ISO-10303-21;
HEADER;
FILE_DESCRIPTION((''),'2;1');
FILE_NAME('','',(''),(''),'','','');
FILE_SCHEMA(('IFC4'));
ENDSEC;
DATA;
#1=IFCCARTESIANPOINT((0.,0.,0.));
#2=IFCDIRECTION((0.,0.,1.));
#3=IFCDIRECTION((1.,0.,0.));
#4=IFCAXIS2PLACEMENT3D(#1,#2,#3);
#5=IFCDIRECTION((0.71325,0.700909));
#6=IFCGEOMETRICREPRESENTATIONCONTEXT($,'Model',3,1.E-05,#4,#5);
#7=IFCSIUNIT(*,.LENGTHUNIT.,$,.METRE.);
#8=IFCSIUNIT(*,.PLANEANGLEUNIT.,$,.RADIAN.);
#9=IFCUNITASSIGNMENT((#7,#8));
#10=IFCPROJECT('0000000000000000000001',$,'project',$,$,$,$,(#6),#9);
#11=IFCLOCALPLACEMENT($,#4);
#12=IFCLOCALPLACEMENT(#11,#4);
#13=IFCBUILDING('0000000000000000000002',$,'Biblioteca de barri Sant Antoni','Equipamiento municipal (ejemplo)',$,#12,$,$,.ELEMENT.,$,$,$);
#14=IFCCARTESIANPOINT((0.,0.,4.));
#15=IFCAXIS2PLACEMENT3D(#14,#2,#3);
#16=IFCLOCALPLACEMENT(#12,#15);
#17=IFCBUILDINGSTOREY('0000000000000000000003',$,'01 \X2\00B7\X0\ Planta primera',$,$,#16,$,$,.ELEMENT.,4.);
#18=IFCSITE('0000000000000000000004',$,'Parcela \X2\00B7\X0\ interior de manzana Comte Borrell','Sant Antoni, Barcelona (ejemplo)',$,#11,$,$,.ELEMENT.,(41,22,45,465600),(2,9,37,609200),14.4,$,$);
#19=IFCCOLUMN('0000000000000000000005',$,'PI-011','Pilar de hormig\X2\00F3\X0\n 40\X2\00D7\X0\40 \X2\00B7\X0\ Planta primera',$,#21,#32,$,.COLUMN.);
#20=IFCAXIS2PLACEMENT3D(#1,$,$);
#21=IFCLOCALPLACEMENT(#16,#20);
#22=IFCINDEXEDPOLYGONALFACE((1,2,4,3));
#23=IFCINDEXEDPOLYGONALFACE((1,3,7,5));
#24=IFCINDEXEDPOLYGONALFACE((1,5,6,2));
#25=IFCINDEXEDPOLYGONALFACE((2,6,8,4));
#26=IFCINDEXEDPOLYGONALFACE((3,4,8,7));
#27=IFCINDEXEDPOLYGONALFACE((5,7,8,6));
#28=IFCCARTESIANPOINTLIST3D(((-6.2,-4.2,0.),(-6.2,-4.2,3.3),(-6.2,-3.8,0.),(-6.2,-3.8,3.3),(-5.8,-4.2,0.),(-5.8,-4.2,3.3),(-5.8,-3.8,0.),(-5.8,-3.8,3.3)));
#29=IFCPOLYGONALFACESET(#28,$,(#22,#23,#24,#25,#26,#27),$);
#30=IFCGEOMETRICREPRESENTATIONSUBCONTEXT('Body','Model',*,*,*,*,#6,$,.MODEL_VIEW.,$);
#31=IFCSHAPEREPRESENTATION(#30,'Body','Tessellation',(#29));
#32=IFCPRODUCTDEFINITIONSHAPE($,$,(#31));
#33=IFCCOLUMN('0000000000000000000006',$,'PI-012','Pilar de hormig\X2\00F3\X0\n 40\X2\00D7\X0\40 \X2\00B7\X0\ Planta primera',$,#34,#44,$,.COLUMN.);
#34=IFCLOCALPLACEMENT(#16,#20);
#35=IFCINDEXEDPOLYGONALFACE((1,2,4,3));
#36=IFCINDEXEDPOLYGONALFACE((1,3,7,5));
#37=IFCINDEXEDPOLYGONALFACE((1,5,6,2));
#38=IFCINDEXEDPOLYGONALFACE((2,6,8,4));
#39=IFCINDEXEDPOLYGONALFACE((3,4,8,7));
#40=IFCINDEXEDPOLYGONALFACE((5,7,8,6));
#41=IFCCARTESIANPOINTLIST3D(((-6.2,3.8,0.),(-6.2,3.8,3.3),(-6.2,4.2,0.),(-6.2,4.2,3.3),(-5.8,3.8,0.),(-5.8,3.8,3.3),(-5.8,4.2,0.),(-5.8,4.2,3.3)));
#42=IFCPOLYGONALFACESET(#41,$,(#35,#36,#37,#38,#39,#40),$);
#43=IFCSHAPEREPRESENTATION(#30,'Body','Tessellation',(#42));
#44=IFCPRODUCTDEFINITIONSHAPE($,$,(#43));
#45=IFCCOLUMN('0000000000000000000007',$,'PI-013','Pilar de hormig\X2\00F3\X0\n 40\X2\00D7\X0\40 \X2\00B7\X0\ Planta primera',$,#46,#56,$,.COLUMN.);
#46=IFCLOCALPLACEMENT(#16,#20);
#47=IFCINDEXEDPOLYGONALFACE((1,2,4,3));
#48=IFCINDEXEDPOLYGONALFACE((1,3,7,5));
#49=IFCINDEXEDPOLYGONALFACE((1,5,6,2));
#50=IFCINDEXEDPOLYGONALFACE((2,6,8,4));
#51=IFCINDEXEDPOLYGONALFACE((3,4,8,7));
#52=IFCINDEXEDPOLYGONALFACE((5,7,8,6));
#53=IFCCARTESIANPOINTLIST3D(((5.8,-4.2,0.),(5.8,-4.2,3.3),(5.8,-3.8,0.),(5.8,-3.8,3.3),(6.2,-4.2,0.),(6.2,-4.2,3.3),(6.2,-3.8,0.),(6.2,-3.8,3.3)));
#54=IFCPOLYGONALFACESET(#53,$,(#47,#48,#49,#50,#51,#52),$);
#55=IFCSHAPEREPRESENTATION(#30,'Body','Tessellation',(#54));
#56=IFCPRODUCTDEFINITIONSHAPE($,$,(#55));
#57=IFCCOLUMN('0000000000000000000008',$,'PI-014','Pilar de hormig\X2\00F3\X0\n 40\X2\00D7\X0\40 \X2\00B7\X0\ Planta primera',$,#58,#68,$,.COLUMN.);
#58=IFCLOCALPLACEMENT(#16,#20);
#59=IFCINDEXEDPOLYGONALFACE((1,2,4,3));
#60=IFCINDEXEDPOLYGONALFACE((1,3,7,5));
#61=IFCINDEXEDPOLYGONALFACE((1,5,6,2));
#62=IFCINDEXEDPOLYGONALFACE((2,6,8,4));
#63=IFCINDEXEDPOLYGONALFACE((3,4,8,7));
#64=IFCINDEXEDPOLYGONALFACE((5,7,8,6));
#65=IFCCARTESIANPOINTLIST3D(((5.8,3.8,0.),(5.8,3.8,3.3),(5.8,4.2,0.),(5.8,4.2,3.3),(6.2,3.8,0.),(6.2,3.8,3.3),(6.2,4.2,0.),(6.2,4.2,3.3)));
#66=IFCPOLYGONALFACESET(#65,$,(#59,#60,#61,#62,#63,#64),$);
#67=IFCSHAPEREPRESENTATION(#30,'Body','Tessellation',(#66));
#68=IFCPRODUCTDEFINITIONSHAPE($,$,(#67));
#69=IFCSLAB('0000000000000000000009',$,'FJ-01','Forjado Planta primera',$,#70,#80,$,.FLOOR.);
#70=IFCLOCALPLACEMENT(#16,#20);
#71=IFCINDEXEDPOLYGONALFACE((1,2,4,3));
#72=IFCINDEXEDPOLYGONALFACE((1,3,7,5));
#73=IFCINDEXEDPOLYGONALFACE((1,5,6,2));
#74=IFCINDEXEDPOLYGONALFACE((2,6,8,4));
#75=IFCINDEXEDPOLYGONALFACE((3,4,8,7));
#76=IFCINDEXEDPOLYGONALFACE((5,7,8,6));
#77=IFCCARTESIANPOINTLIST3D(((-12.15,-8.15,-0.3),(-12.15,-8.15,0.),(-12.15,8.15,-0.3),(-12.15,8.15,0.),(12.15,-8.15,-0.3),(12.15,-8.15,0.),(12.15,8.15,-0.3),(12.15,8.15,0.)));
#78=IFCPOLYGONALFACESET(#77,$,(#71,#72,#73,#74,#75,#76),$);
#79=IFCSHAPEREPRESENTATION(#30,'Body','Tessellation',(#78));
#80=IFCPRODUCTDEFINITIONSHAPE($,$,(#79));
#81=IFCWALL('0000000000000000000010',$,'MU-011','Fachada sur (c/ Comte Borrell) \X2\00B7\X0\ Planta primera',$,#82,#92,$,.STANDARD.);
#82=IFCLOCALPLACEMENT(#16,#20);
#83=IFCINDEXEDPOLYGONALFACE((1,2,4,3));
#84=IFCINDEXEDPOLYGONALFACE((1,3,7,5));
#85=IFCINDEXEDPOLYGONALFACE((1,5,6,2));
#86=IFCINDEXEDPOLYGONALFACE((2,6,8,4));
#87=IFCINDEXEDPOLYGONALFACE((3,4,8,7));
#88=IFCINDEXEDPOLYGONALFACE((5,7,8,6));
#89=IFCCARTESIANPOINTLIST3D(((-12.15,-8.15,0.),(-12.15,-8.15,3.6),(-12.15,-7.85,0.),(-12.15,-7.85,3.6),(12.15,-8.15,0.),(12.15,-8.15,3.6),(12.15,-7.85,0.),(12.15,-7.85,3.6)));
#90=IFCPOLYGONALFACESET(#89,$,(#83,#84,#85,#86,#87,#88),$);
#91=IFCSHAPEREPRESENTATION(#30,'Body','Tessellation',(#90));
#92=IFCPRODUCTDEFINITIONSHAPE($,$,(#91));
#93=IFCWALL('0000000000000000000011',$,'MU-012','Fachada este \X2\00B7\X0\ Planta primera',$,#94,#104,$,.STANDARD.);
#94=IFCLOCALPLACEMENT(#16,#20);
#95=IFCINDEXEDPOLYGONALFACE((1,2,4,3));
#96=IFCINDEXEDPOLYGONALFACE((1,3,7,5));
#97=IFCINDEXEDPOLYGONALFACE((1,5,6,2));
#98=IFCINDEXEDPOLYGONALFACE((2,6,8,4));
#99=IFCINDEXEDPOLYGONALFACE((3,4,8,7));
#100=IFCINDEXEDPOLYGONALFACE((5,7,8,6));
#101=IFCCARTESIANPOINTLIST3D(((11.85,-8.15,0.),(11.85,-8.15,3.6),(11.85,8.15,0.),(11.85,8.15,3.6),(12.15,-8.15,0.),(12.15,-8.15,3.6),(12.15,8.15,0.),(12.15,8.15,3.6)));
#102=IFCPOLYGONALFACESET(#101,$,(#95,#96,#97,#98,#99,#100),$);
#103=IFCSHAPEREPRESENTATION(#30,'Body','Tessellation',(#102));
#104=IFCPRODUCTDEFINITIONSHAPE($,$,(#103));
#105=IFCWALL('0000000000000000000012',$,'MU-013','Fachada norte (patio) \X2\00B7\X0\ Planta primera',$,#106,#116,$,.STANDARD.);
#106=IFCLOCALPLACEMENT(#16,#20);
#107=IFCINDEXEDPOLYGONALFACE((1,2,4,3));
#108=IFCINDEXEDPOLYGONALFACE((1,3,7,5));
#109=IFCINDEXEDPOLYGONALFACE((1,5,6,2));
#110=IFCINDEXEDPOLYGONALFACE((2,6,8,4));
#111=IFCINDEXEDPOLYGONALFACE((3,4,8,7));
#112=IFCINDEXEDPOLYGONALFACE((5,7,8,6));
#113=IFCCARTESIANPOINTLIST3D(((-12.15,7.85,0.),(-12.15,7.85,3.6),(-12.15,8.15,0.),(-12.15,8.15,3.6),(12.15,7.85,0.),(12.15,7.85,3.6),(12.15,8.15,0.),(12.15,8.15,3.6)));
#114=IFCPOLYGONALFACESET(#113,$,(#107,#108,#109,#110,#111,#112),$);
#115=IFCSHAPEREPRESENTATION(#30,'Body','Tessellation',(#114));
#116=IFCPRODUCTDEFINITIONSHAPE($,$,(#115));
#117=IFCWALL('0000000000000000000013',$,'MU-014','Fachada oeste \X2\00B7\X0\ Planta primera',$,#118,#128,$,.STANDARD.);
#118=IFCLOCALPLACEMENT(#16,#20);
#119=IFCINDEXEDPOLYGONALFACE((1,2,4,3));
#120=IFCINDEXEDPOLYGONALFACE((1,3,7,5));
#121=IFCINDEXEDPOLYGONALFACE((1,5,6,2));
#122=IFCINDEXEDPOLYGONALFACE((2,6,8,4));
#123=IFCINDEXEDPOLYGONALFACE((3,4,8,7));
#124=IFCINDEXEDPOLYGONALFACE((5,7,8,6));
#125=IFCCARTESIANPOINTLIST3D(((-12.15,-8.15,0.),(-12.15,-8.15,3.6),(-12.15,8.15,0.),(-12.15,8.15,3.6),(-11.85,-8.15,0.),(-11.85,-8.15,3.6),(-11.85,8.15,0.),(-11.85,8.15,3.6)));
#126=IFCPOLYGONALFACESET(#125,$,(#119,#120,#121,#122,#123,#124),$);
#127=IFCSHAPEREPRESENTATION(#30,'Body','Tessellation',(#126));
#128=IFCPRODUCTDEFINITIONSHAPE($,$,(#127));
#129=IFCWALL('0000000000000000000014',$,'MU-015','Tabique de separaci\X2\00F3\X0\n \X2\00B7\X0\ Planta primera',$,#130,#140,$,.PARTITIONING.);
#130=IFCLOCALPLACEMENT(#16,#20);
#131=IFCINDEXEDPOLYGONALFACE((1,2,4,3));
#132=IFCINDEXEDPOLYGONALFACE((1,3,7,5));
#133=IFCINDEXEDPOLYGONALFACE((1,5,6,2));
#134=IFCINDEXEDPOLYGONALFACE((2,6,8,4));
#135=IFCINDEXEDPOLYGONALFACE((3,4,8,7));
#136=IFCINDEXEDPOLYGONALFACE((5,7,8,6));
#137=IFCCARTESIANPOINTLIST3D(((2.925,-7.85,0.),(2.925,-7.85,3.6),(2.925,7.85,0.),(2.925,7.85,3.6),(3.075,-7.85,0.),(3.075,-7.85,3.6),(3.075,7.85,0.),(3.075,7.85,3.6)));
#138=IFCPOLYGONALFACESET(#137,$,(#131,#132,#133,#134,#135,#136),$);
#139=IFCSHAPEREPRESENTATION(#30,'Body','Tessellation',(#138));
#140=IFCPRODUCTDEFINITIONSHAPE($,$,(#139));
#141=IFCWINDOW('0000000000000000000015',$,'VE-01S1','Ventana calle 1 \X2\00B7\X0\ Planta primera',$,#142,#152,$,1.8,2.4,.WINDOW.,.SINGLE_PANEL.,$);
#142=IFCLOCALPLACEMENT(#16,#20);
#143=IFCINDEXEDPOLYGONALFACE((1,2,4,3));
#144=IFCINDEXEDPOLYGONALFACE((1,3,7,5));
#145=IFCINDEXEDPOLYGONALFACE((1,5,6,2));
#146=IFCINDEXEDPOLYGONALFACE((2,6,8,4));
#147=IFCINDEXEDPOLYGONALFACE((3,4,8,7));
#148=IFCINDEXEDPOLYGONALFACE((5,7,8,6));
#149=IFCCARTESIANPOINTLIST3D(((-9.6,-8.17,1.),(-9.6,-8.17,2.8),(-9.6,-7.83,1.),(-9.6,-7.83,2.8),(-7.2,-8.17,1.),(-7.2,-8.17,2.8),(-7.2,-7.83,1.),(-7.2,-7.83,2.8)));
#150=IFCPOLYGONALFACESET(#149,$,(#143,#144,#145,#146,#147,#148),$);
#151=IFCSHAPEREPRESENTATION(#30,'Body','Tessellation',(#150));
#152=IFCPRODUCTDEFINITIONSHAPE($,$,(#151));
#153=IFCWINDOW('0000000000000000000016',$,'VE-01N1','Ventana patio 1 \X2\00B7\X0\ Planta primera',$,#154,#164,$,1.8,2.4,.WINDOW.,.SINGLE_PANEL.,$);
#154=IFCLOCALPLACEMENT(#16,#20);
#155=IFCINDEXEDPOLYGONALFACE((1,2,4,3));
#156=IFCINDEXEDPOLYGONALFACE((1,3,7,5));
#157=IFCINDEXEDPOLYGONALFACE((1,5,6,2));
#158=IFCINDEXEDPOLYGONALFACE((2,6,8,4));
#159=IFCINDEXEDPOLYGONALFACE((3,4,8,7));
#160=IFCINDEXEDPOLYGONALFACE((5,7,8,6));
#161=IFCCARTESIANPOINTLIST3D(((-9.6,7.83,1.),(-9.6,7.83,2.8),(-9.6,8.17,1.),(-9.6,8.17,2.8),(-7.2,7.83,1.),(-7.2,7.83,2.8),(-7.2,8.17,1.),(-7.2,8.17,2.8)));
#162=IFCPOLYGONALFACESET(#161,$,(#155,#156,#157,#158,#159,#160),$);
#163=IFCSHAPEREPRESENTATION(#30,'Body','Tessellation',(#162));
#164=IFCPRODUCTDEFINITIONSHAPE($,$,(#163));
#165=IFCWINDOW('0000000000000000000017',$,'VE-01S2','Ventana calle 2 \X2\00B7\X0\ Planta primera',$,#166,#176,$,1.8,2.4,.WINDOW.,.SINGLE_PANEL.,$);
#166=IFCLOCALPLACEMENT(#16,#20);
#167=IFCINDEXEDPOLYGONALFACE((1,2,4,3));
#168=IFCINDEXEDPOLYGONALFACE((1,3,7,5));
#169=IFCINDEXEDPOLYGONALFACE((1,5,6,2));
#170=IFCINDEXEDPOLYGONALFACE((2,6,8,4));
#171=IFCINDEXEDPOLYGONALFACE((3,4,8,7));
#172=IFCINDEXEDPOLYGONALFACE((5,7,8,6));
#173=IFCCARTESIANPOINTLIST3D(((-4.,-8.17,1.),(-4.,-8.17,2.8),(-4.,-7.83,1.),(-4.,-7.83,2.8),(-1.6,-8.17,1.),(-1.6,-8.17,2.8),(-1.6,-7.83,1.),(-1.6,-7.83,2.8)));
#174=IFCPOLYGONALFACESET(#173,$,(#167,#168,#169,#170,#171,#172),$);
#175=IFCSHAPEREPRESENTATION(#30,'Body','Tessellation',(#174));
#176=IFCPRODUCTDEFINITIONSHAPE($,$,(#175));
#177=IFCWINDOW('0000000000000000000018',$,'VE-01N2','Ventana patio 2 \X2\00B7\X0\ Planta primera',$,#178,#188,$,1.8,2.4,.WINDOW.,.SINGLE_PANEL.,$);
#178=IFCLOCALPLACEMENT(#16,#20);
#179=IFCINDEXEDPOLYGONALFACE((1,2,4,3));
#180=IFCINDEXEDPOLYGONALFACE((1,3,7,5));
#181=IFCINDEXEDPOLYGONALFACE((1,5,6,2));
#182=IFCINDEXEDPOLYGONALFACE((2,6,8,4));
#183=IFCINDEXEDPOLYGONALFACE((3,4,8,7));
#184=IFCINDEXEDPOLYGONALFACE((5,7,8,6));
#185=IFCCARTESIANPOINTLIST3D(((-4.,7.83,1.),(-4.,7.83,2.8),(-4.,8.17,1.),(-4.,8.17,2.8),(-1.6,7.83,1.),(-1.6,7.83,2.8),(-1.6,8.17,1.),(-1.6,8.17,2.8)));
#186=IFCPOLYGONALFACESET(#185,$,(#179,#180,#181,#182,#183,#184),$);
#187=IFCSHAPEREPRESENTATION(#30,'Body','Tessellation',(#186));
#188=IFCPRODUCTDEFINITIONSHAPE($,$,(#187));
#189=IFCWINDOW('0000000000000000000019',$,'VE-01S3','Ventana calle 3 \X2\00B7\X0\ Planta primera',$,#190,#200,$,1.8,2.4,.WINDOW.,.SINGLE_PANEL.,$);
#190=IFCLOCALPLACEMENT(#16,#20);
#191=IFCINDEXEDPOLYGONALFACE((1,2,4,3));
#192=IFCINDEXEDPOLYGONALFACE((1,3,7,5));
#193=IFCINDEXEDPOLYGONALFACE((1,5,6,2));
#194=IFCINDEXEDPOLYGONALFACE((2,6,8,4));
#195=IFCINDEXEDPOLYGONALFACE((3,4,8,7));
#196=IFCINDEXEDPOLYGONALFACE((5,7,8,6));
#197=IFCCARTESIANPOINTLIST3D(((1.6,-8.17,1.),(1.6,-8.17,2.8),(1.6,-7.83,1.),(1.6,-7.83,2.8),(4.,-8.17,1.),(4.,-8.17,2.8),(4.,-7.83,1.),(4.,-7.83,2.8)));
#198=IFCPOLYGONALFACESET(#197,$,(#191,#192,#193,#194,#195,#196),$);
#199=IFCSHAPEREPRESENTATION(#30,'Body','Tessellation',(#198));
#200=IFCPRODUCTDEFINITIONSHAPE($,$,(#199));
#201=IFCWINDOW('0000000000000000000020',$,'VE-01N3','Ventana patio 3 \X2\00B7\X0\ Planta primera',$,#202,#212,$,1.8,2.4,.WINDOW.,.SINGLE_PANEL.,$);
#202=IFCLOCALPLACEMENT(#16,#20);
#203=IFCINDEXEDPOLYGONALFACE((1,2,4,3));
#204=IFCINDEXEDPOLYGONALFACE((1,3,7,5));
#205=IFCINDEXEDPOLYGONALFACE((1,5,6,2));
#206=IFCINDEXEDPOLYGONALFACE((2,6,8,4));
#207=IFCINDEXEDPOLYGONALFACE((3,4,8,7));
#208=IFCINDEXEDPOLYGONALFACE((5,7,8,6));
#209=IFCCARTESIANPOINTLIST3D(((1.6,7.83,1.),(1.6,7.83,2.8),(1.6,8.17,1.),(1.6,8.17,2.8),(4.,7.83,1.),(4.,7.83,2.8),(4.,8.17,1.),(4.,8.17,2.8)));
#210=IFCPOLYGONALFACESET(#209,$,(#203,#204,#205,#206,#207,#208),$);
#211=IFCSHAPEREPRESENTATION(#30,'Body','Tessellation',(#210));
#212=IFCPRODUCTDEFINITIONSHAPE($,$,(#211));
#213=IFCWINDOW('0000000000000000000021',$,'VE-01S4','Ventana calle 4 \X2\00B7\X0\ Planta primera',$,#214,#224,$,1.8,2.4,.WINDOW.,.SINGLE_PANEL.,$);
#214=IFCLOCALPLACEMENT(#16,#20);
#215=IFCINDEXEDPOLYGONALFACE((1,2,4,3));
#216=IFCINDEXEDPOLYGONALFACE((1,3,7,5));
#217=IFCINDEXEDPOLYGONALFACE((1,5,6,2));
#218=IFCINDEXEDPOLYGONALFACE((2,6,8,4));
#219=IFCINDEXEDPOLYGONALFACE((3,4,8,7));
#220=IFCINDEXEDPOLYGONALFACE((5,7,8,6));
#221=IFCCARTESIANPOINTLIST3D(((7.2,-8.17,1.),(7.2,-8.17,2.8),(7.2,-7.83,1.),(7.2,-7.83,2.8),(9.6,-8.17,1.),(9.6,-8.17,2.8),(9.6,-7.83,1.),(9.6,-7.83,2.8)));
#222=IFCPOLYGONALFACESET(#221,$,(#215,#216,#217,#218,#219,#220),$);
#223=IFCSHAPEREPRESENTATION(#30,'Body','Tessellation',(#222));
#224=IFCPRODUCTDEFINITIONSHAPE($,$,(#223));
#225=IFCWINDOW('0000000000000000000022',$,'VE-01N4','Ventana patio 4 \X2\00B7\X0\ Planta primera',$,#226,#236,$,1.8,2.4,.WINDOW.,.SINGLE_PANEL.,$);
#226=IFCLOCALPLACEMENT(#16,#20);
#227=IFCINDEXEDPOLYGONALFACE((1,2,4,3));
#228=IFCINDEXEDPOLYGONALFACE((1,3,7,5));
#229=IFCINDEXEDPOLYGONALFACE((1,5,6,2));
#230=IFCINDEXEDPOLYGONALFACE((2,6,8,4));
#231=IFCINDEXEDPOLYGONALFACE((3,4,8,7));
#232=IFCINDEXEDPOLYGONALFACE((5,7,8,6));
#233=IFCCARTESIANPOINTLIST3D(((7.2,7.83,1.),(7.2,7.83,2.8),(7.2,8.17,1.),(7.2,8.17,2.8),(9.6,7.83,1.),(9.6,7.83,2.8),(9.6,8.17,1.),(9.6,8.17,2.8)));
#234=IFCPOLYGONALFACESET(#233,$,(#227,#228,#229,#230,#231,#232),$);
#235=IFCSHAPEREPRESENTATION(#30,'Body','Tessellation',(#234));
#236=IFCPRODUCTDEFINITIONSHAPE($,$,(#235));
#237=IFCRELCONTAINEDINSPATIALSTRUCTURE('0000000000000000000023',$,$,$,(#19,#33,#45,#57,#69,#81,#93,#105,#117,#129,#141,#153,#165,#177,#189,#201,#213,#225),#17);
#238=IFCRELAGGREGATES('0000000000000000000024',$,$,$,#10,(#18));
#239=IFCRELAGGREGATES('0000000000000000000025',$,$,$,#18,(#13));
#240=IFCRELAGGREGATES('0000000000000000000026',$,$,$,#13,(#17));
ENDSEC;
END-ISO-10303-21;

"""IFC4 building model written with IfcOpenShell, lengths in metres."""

from ifc_helpers import new_model, si_unit, direction, frame, origin_with_axes, origin_2d, place, context, subcontext, project, spatial, rectangle, extrude, element, save


model = new_model("IFC4")

# Units and contexts
model_context = context("Model", 3, precision=1e-05, world=origin_with_axes(), true_north=direction((0.71325, 0.700909)))
body_context = subcontext(model_context, "Body", "Model", "MODEL_VIEW")
ifc_project = project(units=[si_unit("LENGTHUNIT", "METRE"), si_unit("PLANEANGLEUNIT", "RADIAN")], contexts=[model_context])

# Site, building, storey
site_placement = place(None, origin_with_axes())
site = spatial("IfcSite", under=ifc_project, at=site_placement, Name="Parcela · interior de manzana Comte Borrell", Description="Sant Antoni, Barcelona (ejemplo)", CompositionType="ELEMENT", RefLatitude=(41, 22, 45, 465600), RefLongitude=(2, 9, 37, 609200), RefElevation=14.4)
building_placement = place(site_placement, origin_with_axes())
building = spatial("IfcBuilding", under=site, at=building_placement, Name="Biblioteca de barri Sant Antoni", Description="Equipamiento municipal (ejemplo)", CompositionType="ELEMENT")
storey_placement = place(building_placement, frame((0.0, 0.0, 4.0), z_axis=(0.0, 0.0, 1.0), x_axis=(1.0, 0.0, 0.0)))
storey = spatial("IfcBuildingStorey", under=building, at=storey_placement, Name="01 · Planta primera", CompositionType="ELEMENT", Elevation=4.0)

# Columns
for number, where, z_axis, x_axis, name in (
    (1, (-6.0, -4.0, 0.0), (0.0, 0.0, 1.0), (1.0, 0.0, 0.0), "PI-011"),
    (2, (-6.0, 4.0, 0.0), (0.0, 0.0, 1.0), (1.0, 0.0, 0.0), "PI-012"),
    (3, (6.0, -4.0, 0.0), (0.0, 0.0, 1.0), (1.0, 0.0, 0.0), "PI-013"),
    (4, (6.0, 4.0, 0.0), (0.0, 0.0, 1.0), (1.0, 0.0, 0.0), "PI-014"),
):
    element("IfcColumn", number, at=place(storey_placement, frame(where, z_axis=z_axis, x_axis=x_axis)), inside=storey, Name=name, Description="Pilar de hormigón 40×40 · Planta primera", PredefinedType="COLUMN", context=body_context, shape_type="SweptSolid", body=[
        extrude(rectangle(XDim=0.4, YDim=0.4, at=origin_2d()), origin_with_axes(), (0.0, 0.0, 1.0), 3.3),
    ])

# Slab
slab_placement = place(storey_placement, frame((0.0, 0.0, -0.3), z_axis=(0.0, 0.0, 1.0), x_axis=(1.0, 0.0, 0.0)))
element("IfcSlab", 5, at=slab_placement, inside=storey, Name="FJ-01", Description="Forjado Planta primera", PredefinedType="FLOOR", context=body_context, shape_type="SweptSolid", body=[
    extrude(rectangle(XDim=24.3, YDim=16.3, at=origin_2d()), origin_with_axes(), (0.0, 0.0, 1.0), 0.3),
])

# Walls
wall_1_placement = place(storey_placement, frame((0.0, -8.0, 0.0), z_axis=(0.0, 0.0, 1.0), x_axis=(1.0, 0.0, 0.0)))
element("IfcWall", 6, at=wall_1_placement, inside=storey, Name="MU-011", Description="Fachada sur (c/ Comte Borrell) · Planta primera", PredefinedType="STANDARD", context=body_context, shape_type="SweptSolid", body=[
    extrude(rectangle(XDim=24.3, YDim=0.3, at=origin_2d()), origin_with_axes(), (0.0, 0.0, 1.0), 3.6),
])
wall_2_placement = place(storey_placement, frame((12.0, 0.0, 0.0), z_axis=(0.0, 0.0, 1.0), x_axis=(0.0, 1.0, 0.0)))
element("IfcWall", 7, at=wall_2_placement, inside=storey, Name="MU-012", Description="Fachada este · Planta primera", PredefinedType="STANDARD", context=body_context, shape_type="SweptSolid", body=[
    extrude(rectangle(XDim=16.3, YDim=0.3, at=origin_2d()), origin_with_axes(), (0.0, 0.0, 1.0), 3.6),
])
wall_3_placement = place(storey_placement, frame((0.0, 8.0, 0.0), z_axis=(0.0, 0.0, 1.0), x_axis=(-1.0, 0.0, 0.0)))
element("IfcWall", 8, at=wall_3_placement, inside=storey, Name="MU-013", Description="Fachada norte (patio) · Planta primera", PredefinedType="STANDARD", context=body_context, shape_type="SweptSolid", body=[
    extrude(rectangle(XDim=24.3, YDim=0.3, at=origin_2d()), origin_with_axes(), (0.0, 0.0, 1.0), 3.6),
])
wall_4_placement = place(storey_placement, frame((-12.0, 0.0, 0.0), z_axis=(0.0, 0.0, 1.0), x_axis=(0.0, -1.0, 0.0)))
element("IfcWall", 9, at=wall_4_placement, inside=storey, Name="MU-014", Description="Fachada oeste · Planta primera", PredefinedType="STANDARD", context=body_context, shape_type="SweptSolid", body=[
    extrude(rectangle(XDim=16.3, YDim=0.3, at=origin_2d()), origin_with_axes(), (0.0, 0.0, 1.0), 3.6),
])
wall_5_placement = place(storey_placement, frame((3.0, 0.0, 0.0), z_axis=(0.0, 0.0, 1.0), x_axis=(1.0, 0.0, 0.0)))
element("IfcWall", 10, at=wall_5_placement, inside=storey, Name="MU-015", Description="Tabique de separación · Planta primera", PredefinedType="PARTITIONING", context=body_context, shape_type="SweptSolid", body=[
    extrude(rectangle(XDim=0.15, YDim=15.7, at=origin_2d()), origin_with_axes(), (0.0, 0.0, 1.0), 3.6),
])

# Windows
for number, where, z_axis, x_axis, name, description in (
    (11, (-8.4, -8.0, 1.0), (0.0, 0.0, 1.0), (1.0, 0.0, 0.0), "VE-01S1", "Ventana calle 1 · Planta primera"),
    (12, (-8.4, 8.0, 1.0), (0.0, 0.0, 1.0), (1.0, 0.0, 0.0), "VE-01N1", "Ventana patio 1 · Planta primera"),
    (13, (-2.8, -8.0, 1.0), (0.0, 0.0, 1.0), (1.0, 0.0, 0.0), "VE-01S2", "Ventana calle 2 · Planta primera"),
    (14, (-2.8, 8.0, 1.0), (0.0, 0.0, 1.0), (1.0, 0.0, 0.0), "VE-01N2", "Ventana patio 2 · Planta primera"),
    (15, (2.8, -8.0, 1.0), (0.0, 0.0, 1.0), (1.0, 0.0, 0.0), "VE-01S3", "Ventana calle 3 · Planta primera"),
    (16, (2.8, 8.0, 1.0), (0.0, 0.0, 1.0), (1.0, 0.0, 0.0), "VE-01N3", "Ventana patio 3 · Planta primera"),
    (17, (8.4, -8.0, 1.0), (0.0, 0.0, 1.0), (1.0, 0.0, 0.0), "VE-01S4", "Ventana calle 4 · Planta primera"),
    (18, (8.4, 8.0, 1.0), (0.0, 0.0, 1.0), (1.0, 0.0, 0.0), "VE-01N4", "Ventana patio 4 · Planta primera"),
):
    element("IfcWindow", number, at=place(storey_placement, frame(where, z_axis=z_axis, x_axis=x_axis)), inside=storey, Name=name, Description=description, OverallHeight=1.8, OverallWidth=2.4, PartitioningType="SINGLE_PANEL", PredefinedType="WINDOW", context=body_context, shape_type="SweptSolid", body=[
        extrude(rectangle(XDim=2.4, YDim=0.34, at=origin_2d()), origin_with_axes(), (0.0, 0.0, 1.0), 1.8),
    ])

save(model, "model.ifc")
